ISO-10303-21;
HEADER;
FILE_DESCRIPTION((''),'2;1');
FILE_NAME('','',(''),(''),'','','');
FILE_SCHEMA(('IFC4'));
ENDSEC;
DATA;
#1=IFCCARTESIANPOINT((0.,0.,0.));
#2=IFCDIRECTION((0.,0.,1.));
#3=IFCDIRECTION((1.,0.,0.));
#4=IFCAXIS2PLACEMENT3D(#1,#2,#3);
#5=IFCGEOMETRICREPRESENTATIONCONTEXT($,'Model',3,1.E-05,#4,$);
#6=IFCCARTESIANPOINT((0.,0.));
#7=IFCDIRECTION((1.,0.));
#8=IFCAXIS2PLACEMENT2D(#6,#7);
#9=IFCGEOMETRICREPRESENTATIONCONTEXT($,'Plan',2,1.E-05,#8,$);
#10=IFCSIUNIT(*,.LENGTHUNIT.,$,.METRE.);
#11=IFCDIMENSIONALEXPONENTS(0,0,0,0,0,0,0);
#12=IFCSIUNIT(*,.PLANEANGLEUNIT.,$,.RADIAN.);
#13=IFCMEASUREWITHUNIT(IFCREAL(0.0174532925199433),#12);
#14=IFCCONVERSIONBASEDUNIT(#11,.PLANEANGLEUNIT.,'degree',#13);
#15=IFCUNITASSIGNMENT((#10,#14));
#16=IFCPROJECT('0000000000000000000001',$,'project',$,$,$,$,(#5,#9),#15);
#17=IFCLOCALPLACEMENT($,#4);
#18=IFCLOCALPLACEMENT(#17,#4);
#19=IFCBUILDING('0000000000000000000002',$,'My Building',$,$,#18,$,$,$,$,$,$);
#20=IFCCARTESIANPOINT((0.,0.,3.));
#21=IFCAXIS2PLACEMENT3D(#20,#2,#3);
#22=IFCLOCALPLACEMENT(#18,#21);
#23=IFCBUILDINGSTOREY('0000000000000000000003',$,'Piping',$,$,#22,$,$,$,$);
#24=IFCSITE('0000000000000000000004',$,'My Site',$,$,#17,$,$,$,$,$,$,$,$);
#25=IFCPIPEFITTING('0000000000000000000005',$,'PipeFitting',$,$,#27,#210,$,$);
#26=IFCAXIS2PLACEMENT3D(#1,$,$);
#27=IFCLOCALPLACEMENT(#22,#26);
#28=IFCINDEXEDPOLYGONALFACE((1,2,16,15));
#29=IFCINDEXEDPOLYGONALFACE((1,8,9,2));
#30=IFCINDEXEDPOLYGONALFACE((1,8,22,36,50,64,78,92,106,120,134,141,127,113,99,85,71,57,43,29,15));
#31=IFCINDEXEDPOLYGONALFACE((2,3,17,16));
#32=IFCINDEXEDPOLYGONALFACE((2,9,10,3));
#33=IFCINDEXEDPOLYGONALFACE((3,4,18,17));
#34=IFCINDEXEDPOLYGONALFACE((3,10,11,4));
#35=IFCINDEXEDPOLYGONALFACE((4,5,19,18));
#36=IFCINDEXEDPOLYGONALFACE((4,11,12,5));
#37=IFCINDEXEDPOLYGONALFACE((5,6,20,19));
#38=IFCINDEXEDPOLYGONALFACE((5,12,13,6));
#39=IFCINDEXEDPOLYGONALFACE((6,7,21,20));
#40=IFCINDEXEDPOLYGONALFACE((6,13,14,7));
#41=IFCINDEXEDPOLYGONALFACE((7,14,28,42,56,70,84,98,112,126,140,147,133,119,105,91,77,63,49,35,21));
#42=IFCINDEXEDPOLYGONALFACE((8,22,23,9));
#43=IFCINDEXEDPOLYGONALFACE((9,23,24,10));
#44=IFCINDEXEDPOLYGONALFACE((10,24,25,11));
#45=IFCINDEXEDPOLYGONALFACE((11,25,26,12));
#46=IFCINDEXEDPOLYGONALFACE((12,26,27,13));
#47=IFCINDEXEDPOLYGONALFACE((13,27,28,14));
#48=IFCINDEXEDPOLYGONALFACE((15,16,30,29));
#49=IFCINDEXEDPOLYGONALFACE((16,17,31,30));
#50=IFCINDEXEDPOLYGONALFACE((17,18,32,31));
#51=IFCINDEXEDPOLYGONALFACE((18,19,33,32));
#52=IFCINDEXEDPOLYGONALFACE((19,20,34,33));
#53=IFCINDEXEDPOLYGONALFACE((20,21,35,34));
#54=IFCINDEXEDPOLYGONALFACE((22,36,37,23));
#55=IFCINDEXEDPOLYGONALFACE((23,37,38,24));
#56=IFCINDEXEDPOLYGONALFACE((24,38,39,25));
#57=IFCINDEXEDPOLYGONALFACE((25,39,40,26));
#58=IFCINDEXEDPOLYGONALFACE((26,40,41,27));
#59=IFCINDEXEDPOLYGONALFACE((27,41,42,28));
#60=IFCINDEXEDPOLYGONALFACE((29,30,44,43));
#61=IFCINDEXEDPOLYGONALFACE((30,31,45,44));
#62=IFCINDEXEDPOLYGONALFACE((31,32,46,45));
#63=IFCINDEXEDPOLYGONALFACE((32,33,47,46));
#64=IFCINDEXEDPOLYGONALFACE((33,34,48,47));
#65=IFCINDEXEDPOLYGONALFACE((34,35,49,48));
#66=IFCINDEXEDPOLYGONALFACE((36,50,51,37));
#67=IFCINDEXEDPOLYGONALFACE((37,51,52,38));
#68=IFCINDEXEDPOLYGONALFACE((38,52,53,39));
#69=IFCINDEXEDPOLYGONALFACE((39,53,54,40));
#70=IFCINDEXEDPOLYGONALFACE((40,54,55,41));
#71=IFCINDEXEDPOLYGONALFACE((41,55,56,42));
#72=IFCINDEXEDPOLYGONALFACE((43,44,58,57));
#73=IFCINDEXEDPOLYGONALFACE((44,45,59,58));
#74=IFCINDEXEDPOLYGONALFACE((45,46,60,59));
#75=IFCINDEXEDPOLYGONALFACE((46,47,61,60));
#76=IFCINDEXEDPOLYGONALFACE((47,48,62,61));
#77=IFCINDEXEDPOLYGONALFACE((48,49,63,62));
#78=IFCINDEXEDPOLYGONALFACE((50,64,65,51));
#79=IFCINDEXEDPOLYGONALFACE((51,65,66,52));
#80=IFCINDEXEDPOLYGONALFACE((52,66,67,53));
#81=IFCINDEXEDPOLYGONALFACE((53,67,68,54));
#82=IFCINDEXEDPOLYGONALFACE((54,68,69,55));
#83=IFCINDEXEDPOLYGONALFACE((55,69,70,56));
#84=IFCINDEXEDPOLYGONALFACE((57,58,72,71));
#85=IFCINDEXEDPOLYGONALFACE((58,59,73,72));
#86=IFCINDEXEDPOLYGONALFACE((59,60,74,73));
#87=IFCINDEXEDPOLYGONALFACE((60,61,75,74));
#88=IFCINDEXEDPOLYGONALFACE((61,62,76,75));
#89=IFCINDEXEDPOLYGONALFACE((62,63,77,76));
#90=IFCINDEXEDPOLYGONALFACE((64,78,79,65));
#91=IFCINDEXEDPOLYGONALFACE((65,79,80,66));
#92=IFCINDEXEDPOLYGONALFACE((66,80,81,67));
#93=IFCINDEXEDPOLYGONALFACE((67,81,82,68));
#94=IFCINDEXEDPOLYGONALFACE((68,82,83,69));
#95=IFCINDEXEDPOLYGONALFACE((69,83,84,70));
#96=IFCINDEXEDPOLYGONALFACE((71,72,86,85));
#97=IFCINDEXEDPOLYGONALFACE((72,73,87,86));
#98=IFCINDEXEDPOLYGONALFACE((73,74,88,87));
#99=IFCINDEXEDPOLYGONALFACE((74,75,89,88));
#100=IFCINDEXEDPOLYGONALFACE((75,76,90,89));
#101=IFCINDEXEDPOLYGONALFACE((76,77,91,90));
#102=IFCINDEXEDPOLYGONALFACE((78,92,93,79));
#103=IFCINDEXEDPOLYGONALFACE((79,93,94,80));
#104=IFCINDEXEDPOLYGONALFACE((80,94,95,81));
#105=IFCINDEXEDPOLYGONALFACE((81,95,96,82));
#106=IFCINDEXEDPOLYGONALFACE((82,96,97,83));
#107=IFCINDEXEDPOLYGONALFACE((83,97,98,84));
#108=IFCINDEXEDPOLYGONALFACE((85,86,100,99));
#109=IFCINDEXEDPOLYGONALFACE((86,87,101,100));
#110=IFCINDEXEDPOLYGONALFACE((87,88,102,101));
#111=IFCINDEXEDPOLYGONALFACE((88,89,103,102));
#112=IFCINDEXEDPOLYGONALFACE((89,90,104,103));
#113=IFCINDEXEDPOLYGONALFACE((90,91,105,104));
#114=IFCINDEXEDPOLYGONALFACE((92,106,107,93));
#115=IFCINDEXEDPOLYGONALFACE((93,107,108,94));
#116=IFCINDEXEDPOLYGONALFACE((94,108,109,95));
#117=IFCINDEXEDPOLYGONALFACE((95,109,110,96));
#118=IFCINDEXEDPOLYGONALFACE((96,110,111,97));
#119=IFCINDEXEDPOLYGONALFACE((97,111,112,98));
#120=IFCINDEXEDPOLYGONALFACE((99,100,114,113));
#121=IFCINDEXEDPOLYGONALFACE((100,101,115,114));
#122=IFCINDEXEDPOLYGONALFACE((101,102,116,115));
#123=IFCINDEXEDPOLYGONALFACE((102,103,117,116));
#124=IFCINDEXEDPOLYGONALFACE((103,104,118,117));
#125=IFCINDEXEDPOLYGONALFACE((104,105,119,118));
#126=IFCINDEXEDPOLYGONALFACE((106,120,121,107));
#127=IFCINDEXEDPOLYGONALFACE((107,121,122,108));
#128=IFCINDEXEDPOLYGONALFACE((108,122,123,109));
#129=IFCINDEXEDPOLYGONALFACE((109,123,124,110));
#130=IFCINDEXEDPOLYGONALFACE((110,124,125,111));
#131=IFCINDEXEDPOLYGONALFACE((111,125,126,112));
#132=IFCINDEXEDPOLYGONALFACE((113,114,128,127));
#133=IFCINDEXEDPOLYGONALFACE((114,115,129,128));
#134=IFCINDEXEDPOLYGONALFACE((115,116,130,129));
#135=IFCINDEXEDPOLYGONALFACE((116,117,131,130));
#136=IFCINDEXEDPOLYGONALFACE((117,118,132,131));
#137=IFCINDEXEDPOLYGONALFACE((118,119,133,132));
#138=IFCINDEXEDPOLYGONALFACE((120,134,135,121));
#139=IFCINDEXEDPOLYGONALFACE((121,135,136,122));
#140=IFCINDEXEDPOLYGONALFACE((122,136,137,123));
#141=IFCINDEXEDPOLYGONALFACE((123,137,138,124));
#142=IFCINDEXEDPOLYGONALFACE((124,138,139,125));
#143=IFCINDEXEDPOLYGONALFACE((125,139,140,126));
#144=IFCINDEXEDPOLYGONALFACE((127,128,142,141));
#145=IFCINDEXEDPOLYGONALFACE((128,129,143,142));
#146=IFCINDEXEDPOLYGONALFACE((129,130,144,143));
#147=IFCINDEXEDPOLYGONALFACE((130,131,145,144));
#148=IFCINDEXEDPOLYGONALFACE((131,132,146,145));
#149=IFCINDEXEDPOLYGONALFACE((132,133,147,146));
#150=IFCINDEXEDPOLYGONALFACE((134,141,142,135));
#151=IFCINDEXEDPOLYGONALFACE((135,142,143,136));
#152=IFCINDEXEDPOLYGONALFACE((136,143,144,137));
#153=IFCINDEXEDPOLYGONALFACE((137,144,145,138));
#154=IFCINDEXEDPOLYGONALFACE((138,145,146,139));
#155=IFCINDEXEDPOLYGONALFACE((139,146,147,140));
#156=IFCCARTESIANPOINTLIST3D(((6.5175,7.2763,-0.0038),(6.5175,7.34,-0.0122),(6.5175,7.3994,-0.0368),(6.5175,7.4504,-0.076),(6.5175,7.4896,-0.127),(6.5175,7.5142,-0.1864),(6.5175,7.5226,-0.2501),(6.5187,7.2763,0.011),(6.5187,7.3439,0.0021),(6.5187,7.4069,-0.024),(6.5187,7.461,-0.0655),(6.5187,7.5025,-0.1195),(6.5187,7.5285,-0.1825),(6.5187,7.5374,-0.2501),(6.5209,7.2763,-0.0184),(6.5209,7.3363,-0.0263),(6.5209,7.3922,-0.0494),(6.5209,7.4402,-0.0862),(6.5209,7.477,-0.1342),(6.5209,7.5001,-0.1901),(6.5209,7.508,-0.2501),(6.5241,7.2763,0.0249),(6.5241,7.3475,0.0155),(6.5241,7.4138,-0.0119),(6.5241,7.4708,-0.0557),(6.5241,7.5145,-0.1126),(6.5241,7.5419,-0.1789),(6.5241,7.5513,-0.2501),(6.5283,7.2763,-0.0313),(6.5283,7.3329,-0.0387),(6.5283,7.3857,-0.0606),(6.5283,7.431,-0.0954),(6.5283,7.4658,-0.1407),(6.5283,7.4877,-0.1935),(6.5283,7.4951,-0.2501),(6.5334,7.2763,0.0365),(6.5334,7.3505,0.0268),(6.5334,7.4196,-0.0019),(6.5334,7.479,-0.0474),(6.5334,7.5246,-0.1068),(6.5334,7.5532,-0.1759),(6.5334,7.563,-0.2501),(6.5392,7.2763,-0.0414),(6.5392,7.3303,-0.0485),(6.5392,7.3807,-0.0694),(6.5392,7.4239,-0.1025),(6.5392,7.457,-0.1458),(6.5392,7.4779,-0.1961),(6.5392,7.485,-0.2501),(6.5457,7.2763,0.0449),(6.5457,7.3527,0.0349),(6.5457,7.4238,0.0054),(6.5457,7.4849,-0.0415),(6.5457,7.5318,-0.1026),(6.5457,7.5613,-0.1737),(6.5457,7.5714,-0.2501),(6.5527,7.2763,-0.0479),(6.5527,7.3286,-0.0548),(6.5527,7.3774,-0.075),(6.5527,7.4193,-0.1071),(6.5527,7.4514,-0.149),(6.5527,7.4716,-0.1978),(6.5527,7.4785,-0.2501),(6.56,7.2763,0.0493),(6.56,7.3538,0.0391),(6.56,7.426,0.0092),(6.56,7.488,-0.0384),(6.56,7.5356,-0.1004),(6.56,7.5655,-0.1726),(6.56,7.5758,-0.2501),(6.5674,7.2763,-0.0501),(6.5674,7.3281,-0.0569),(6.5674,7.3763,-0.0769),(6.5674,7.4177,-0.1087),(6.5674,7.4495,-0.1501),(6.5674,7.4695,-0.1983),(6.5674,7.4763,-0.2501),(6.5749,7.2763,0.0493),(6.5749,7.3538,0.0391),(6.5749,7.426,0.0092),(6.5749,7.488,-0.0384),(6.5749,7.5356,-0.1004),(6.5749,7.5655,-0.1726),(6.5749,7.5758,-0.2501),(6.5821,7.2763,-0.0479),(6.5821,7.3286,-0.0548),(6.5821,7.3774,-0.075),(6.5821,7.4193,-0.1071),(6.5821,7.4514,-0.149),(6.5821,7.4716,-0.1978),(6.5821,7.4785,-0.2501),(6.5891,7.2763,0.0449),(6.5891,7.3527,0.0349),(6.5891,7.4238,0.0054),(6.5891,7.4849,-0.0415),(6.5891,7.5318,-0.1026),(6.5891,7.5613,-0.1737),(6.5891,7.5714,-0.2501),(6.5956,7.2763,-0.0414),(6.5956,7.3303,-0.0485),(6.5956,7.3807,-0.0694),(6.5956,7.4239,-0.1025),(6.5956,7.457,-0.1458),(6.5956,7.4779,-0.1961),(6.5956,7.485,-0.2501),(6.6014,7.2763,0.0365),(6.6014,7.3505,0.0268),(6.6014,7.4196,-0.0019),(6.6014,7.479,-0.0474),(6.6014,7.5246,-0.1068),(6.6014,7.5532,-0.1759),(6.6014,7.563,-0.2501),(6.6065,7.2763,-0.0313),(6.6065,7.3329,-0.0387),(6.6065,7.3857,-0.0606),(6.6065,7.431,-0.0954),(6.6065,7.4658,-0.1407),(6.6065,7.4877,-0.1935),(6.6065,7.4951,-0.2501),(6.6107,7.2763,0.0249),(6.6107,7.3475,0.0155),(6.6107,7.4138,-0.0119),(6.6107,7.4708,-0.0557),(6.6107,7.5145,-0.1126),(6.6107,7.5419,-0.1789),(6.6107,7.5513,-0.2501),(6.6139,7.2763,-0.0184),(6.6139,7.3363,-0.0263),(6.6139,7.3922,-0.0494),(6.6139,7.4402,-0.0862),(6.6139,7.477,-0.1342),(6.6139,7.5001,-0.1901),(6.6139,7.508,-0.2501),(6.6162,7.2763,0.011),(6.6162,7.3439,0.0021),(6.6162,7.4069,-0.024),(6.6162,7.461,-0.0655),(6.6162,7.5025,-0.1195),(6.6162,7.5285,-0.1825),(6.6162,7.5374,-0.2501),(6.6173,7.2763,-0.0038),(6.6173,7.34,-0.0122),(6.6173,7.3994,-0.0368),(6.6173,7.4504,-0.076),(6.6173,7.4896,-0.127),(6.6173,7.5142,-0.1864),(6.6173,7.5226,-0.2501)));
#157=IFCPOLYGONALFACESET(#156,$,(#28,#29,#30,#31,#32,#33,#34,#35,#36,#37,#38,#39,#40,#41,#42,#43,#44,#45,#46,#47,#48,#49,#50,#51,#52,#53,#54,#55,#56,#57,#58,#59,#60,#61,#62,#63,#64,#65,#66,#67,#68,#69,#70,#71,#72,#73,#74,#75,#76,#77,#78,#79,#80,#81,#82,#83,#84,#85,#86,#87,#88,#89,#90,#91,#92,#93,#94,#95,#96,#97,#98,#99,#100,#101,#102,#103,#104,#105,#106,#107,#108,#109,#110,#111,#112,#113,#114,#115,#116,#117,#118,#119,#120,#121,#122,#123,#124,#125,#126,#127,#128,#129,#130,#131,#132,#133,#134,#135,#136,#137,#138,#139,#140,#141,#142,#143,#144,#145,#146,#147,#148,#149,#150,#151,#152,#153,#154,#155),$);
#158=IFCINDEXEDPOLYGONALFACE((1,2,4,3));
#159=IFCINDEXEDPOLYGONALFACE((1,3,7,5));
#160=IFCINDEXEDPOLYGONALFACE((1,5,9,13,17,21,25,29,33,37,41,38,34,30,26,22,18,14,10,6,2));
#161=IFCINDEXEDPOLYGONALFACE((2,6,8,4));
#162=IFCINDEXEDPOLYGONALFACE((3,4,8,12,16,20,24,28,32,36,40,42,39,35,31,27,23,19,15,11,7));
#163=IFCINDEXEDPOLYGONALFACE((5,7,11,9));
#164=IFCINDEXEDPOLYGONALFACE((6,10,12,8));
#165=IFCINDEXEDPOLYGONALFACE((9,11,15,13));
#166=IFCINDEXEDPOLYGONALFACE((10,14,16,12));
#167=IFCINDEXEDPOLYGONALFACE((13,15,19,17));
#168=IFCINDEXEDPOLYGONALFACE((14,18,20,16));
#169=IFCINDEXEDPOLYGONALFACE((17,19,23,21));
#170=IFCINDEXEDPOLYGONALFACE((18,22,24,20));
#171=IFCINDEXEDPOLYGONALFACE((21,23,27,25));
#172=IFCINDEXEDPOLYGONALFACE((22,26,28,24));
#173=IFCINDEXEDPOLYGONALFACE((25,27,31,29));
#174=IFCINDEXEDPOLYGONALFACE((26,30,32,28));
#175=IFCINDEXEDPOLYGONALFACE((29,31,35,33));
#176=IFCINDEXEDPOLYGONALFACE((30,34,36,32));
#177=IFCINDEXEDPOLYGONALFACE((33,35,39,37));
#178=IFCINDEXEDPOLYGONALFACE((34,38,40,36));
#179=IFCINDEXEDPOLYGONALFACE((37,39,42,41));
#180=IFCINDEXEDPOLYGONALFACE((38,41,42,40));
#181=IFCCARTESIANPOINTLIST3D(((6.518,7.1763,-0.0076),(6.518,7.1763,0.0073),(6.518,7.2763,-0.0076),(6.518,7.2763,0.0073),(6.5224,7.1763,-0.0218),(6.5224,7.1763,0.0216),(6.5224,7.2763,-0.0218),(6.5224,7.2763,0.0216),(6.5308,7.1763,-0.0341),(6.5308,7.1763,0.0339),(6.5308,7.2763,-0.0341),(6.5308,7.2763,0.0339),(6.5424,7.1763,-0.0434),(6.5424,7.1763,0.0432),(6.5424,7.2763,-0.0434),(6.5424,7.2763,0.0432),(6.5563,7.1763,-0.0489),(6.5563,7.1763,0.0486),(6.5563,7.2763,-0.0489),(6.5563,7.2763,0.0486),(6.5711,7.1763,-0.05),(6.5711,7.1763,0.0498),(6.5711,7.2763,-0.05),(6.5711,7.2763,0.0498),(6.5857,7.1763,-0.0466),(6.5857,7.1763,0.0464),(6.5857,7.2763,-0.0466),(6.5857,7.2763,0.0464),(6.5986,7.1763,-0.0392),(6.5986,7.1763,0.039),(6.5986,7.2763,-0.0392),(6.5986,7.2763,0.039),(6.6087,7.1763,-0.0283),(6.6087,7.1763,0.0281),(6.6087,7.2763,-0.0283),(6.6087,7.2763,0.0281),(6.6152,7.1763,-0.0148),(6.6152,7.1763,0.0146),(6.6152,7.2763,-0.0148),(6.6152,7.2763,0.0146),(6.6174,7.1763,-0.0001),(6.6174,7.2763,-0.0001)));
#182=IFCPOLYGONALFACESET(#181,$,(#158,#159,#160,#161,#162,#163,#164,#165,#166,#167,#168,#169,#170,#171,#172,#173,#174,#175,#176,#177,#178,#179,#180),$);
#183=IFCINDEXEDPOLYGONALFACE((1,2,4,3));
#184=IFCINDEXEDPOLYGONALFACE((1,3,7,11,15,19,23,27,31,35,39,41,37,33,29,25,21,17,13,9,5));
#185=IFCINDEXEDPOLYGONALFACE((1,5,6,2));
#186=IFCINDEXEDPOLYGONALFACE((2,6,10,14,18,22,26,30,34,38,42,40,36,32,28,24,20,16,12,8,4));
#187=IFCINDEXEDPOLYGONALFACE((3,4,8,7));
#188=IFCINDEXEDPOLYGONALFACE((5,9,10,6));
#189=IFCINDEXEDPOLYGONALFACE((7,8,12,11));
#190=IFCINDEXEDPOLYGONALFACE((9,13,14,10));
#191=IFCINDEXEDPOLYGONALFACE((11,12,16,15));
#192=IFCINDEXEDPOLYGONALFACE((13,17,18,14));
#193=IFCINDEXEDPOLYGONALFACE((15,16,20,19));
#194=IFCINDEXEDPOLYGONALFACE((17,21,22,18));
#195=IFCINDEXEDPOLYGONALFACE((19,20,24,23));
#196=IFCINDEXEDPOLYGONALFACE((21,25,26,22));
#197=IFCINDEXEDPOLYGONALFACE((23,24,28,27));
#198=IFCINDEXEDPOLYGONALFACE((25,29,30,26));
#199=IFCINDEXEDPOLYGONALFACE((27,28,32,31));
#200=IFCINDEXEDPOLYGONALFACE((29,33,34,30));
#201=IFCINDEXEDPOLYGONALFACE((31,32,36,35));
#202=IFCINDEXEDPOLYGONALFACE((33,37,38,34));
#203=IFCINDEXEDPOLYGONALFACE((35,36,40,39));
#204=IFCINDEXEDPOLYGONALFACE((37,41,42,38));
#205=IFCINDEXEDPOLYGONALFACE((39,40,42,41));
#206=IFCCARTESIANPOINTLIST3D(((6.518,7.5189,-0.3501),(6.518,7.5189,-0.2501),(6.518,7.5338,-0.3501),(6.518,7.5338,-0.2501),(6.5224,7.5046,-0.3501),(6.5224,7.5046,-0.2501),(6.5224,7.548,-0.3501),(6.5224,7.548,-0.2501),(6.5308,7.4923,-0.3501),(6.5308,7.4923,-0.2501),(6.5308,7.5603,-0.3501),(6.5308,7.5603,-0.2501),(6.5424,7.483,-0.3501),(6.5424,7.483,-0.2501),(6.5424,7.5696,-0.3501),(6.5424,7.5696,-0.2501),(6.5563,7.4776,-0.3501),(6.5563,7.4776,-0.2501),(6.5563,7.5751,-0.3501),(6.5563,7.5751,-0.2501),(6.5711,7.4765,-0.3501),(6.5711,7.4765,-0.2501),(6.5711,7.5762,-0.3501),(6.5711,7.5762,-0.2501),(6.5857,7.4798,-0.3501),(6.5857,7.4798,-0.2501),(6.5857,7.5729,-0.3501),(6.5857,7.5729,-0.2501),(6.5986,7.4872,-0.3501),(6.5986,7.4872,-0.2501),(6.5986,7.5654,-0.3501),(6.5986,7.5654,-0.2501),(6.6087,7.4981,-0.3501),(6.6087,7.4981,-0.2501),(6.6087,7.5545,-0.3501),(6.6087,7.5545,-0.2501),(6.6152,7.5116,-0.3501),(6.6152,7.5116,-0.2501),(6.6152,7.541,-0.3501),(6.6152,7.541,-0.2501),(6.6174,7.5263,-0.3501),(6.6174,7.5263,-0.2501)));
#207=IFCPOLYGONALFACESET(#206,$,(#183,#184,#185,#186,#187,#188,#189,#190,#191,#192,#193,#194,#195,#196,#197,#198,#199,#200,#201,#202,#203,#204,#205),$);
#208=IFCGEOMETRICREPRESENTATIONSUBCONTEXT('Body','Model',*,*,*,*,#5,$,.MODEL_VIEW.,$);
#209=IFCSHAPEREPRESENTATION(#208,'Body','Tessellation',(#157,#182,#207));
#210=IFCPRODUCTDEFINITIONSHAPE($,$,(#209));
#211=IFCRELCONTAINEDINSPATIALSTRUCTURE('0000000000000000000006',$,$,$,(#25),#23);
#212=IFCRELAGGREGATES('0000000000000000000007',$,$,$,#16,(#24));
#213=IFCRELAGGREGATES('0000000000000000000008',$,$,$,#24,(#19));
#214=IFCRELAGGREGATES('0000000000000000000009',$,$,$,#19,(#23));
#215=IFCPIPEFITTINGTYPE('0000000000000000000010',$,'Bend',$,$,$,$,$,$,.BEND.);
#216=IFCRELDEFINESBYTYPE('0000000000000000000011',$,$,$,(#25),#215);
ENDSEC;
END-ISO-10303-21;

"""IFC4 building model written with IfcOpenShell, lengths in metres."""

from ifc_helpers import new_model, entity, si_unit, converted_unit, frame, origin_with_axes, origin_2d_with_axis, place, context, subcontext, project, spatial, circle, extrude, source, transform, mapped, type_object, type_shapes, element, save


model = new_model("IFC4")

# Units and contexts
model_context = context("Model", 3, precision=1e-05, world=origin_with_axes())
plan_context = context("Plan", 2, precision=1e-05, world=origin_2d_with_axis())
body_context = subcontext(model_context, "Body", "Model", "MODEL_VIEW")
ifc_project = project(units=[si_unit("LENGTHUNIT", "METRE"), converted_unit("PLANEANGLEUNIT", "degree", entity("IfcReal", 0.0174532925199433), si_unit("PLANEANGLEUNIT", "RADIAN"), dimensions=[0, 0, 0, 0, 0, 0, 0])], contexts=[model_context, plan_context])

# Site, building, storey
site_placement = place(None, origin_with_axes())
site = spatial("IfcSite", under=ifc_project, at=site_placement, Name="My Site")
building_placement = place(site_placement, origin_with_axes())
building = spatial("IfcBuilding", under=site, at=building_placement, Name="My Building")
storey_placement = place(building_placement, frame((0.0, 0.0, 3.0), z_axis=(0.0, 0.0, 1.0), x_axis=(1.0, 0.0, 0.0)))
storey = spatial("IfcBuildingStorey", under=building, at=storey_placement, Name="Piping")

# Pipe fitting
pipe_fitting_type = type_object("IfcPipeFittingType", Name="Bend", PredefinedType="BEND")
shared_shape = source(origin_with_axes(), body_context, "Body", "SolidModel", [
    entity("IfcSweptDiskSolid", entity("IfcIndexedPolyCurve", entity("IfcCartesianPointList3D", [[0.0, 0.0, -0.1], [0.0, -0.0732, -0.2768], [0.0, -0.25, -0.35]]), [entity("IfcArcIndex", [1, 2, 3])]), 0.05),
    extrude(circle(Radius=0.05), origin_with_axes(), (0.0, 0.0, -1.0), 0.1),
    extrude(circle(Radius=0.05), frame((0.0, -0.25, -0.35), z_axis=(0.0, -1.0, 0.0), x_axis=(1.0, 0.0, 0.0)), (0.0, 0.0, 1.0), 0.1),
])
type_shapes(pipe_fitting_type, [shared_shape])
for number, where, z_axis, x_axis, name in (
    (1, (6.5674, 7.1763, -0.0001), (0.0, -1.0, 0.0), (1.0, 0.0, 0.0), "PipeFitting"),
):
    element("IfcPipeFitting", number, at=place(storey_placement, frame(where, z_axis=z_axis, x_axis=x_axis)), inside=storey, type_object=pipe_fitting_type, Name=name, context=body_context, shape_type="MappedRepresentation", body=[
        mapped(shared_shape, transform((0.0, 0.0, 0.0), x_axis=(1.0, 0.0, 0.0), y_axis=(0.0, 1.0, 0.0), z_axis=(0.0, 0.0, 1.0), scale=1.0)),
    ])

save(model, "model.ifc")
